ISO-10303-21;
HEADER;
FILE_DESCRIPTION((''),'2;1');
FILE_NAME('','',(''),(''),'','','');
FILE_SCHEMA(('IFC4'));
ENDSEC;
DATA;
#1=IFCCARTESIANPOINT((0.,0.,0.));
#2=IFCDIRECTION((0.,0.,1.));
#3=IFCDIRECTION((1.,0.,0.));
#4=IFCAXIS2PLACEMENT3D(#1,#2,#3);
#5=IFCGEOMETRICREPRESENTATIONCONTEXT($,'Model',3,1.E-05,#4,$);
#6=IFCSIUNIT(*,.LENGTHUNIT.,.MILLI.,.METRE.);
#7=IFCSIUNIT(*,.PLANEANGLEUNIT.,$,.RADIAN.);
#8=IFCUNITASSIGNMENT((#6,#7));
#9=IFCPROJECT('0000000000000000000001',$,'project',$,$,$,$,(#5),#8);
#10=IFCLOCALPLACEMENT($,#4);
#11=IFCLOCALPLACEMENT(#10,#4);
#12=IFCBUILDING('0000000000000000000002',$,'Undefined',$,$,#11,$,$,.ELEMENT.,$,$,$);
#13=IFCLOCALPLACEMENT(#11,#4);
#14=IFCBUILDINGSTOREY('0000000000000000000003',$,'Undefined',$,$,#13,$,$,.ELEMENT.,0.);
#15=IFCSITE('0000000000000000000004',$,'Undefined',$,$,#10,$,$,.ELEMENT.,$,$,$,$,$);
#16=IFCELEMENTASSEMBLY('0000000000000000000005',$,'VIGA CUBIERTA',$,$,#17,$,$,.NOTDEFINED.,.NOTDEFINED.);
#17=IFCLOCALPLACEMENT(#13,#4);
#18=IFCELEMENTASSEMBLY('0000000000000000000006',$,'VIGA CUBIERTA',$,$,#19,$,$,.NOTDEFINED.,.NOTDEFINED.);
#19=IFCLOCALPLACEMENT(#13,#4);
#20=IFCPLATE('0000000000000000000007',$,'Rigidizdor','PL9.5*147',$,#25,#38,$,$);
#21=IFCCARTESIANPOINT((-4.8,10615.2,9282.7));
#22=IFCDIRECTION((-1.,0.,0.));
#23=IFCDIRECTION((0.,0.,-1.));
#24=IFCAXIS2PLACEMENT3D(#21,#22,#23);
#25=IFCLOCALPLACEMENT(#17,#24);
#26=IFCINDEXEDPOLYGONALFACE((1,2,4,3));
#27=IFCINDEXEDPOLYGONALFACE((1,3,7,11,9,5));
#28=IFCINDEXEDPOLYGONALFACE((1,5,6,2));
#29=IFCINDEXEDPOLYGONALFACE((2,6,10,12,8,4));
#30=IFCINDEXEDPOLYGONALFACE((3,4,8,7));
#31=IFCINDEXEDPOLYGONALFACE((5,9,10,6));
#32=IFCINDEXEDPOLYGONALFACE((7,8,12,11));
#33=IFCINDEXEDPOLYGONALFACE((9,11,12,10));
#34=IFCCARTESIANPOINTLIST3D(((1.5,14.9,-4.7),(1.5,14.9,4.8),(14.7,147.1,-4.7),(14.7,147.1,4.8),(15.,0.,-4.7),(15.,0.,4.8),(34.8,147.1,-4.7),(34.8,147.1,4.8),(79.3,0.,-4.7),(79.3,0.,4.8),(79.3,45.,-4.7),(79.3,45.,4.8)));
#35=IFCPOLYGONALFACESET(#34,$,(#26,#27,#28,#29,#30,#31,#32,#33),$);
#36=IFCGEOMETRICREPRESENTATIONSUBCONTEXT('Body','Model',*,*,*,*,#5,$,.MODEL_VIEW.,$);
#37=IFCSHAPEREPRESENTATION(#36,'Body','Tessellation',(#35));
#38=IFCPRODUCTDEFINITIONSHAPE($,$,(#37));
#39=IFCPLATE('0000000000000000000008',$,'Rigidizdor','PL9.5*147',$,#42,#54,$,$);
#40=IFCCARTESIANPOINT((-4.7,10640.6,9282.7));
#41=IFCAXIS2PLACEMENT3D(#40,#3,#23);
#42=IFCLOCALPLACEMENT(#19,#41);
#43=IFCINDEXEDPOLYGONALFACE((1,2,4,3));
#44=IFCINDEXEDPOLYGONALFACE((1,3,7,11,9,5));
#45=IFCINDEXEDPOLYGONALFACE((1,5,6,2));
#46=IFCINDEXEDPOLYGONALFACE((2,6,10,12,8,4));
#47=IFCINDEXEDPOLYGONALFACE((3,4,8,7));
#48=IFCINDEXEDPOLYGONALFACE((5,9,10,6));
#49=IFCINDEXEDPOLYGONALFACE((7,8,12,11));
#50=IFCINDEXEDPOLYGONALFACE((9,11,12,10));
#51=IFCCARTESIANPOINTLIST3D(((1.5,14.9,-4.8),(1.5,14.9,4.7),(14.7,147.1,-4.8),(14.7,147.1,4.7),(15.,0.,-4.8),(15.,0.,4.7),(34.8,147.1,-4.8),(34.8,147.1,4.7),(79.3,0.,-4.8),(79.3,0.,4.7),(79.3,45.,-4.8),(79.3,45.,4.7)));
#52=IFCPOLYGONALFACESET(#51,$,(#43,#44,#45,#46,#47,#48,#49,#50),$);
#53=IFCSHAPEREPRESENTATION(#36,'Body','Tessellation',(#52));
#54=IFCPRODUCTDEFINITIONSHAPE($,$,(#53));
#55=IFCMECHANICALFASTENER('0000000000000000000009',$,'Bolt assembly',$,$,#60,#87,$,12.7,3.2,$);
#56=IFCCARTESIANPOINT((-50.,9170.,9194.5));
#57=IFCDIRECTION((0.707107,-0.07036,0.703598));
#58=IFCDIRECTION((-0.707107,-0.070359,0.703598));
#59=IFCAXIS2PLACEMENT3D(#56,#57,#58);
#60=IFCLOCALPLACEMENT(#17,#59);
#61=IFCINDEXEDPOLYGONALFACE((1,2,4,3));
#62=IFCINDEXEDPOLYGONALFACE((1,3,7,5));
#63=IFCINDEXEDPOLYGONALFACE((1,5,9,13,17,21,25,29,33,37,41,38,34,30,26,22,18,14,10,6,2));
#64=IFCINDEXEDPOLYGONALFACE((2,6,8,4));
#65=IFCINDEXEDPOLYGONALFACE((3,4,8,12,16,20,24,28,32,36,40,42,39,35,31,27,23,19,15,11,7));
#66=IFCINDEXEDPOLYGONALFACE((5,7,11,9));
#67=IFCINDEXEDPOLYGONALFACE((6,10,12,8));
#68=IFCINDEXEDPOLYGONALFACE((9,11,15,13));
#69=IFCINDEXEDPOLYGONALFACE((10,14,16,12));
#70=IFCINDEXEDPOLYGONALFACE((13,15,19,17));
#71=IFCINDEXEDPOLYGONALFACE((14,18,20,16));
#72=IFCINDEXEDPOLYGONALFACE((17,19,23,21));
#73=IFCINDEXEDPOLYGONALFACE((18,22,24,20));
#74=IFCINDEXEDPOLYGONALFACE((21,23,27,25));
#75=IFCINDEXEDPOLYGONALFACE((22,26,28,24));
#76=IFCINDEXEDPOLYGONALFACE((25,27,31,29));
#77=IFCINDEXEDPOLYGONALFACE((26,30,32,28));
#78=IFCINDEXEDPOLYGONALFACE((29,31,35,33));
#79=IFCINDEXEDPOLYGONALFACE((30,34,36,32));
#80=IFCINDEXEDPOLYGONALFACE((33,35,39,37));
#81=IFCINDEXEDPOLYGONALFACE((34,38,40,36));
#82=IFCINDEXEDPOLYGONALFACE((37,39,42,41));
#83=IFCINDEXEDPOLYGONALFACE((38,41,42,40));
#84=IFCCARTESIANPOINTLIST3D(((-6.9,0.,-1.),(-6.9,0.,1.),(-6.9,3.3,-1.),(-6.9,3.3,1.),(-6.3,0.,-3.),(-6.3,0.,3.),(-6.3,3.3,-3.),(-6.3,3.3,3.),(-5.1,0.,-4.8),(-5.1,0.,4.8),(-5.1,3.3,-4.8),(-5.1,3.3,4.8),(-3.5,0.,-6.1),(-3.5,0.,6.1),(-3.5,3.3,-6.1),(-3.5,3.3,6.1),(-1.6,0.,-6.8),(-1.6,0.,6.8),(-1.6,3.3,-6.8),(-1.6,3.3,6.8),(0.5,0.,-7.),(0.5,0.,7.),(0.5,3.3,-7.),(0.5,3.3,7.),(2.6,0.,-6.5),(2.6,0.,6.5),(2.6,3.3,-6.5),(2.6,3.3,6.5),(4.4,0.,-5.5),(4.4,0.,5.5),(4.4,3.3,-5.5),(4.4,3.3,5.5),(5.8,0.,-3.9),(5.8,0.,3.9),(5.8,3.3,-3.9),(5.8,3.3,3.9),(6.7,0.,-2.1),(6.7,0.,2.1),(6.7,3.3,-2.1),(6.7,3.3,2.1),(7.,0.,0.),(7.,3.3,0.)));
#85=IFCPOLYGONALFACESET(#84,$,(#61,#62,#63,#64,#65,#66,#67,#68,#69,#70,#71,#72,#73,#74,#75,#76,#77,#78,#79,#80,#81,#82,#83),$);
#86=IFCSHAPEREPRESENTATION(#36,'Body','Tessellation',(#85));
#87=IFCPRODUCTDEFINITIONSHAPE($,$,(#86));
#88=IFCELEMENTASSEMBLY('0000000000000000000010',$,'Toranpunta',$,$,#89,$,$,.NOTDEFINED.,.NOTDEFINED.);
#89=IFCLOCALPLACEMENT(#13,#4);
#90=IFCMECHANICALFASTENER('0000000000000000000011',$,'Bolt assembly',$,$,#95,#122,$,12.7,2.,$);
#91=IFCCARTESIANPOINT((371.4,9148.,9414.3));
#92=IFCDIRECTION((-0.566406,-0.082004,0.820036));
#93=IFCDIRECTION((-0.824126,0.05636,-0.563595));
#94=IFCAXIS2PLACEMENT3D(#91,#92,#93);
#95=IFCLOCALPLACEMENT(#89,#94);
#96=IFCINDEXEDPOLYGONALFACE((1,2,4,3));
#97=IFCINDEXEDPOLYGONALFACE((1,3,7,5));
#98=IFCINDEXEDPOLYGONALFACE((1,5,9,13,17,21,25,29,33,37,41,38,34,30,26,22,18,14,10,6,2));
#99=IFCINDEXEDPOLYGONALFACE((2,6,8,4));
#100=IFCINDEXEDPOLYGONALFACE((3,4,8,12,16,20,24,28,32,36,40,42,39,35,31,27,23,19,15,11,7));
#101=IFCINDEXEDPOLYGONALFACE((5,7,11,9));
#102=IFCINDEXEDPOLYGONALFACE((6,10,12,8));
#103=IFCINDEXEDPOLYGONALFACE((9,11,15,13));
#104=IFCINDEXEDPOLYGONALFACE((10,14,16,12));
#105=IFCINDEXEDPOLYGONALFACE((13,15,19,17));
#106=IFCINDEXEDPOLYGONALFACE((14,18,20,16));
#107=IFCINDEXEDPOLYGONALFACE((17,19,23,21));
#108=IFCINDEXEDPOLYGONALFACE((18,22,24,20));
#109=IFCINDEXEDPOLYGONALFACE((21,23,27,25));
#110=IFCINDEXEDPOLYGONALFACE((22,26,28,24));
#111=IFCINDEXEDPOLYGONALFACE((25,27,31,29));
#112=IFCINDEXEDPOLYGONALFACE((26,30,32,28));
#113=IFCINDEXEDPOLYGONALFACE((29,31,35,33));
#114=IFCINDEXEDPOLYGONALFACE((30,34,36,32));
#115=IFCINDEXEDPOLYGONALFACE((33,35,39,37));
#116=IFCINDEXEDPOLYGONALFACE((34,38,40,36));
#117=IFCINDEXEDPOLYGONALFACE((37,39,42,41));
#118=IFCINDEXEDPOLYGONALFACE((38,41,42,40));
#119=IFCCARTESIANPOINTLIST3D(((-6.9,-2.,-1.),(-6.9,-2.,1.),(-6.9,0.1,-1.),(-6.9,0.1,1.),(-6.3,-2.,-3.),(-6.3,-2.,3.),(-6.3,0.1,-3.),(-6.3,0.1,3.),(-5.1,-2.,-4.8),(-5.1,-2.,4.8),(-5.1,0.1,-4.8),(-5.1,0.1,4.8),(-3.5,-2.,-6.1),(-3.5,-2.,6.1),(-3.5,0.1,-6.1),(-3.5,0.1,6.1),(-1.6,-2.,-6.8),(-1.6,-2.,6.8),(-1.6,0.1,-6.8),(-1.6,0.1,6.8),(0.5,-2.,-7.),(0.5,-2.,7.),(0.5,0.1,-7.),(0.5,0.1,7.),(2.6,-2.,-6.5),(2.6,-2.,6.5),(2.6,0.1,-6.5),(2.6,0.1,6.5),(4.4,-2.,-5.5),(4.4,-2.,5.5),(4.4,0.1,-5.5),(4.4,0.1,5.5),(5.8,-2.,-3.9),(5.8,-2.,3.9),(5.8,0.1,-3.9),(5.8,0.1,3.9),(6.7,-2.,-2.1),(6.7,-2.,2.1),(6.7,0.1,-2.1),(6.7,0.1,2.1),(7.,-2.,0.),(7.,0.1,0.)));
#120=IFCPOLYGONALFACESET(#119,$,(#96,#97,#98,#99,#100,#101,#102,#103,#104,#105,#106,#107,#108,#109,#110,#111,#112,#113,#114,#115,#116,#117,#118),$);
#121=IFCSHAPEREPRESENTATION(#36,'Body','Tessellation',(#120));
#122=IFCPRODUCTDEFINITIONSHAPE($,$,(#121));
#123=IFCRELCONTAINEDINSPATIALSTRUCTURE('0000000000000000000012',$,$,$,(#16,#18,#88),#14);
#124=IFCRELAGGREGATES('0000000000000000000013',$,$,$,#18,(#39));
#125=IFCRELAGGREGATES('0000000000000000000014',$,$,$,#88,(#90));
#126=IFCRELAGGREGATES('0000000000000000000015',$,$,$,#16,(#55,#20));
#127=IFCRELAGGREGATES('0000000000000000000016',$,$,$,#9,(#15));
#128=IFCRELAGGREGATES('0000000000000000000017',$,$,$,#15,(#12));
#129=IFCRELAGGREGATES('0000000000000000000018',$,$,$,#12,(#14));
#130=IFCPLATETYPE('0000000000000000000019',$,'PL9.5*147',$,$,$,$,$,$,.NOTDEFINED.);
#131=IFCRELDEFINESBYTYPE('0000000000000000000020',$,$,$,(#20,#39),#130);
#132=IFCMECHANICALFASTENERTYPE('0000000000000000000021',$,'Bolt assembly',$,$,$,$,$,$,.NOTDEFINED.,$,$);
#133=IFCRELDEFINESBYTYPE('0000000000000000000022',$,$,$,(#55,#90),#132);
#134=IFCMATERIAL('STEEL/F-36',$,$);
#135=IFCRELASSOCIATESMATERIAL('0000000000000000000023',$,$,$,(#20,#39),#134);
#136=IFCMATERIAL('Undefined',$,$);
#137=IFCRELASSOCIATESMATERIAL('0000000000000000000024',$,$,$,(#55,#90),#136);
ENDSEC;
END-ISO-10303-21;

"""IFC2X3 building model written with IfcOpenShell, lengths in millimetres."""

from ifc_helpers import new_model, si_unit, frame, origin_with_axes, origin_2d_with_axis, place, context, subcontext, project, spatial, polyline, circle, outline, extrude, source, transform, mapped, material, type_object, element, aggregate, save


model = new_model("IFC2X3")

# Units and contexts
model_context = context("Model", 3, precision=1e-05, world=origin_with_axes())
body_context = subcontext(model_context, "Body", "Model", "MODEL_VIEW")
ifc_project = project(units=[si_unit("LENGTHUNIT", "METRE", prefix="MILLI"), si_unit("PLANEANGLEUNIT", "RADIAN")], contexts=[model_context])

# Site, building, storey
site_placement = place(None, origin_with_axes())
site = spatial("IfcSite", under=ifc_project, at=site_placement, Name="Undefined", CompositionType="ELEMENT")
building_placement = place(site_placement, origin_with_axes())
building = spatial("IfcBuilding", under=site, at=building_placement, Name="Undefined", CompositionType="ELEMENT")
storey_placement = place(building_placement, origin_with_axes())
storey = spatial("IfcBuildingStorey", under=building, at=storey_placement, Name="Undefined", CompositionType="ELEMENT", Elevation=0.0)

# Element assemblies
assembly_1_placement = place(storey_placement, origin_with_axes())
assembly_1 = element("IfcElementAssembly", 1, at=assembly_1_placement, inside=storey, Name="VIGA CUBIERTA", AssemblyPlace="NOTDEFINED", PredefinedType="NOTDEFINED")
ifc_material_1 = material(Name="STEEL/F-36")
assembly_2_placement = place(storey_placement, origin_with_axes())
assembly_2 = element("IfcElementAssembly", 2, at=assembly_2_placement, inside=storey, Name="VIGA CUBIERTA", AssemblyPlace="NOTDEFINED", PredefinedType="NOTDEFINED")

# Plates
plate_type_1 = type_object("IfcPlateType", Name="PL9.5*147", PredefinedType="NOTDEFINED")
plate_1_placement = place(assembly_1_placement, frame((-4.8, 10615.2, 9282.7), z_axis=(-1.0, 0.0, 0.0), x_axis=(0.0, 0.0, -1.0)))
plate_1 = element("IfcPlate", 3, at=plate_1_placement, type_object=plate_type_1, material=ifc_material_1, Name="Rigidizdor", Description="PL9.5*147", context=body_context, shape_type="SweptSolid", body=[
    extrude(outline(polyline([(1.5, 14.9), (15.0, 0.0), (79.3, 0.0), (79.3, 45.0), (34.8, 147.1), (14.7, 147.1), (1.5, 14.9)])), frame((0.0, 0.0, -4.7), z_axis=(0.0, 0.0, 1.0), x_axis=(1.0, 0.0, 0.0)), (0.0, 0.0, 1.0), 9.5),
])
plate_2_placement = place(assembly_2_placement, frame((-4.7, 10640.6, 9282.7), z_axis=(1.0, 0.0, 0.0), x_axis=(0.0, 0.0, -1.0)))
plate_2 = element("IfcPlate", 4, at=plate_2_placement, type_object=plate_type_1, material=ifc_material_1, Name="Rigidizdor", Description="PL9.5*147", context=body_context, shape_type="SweptSolid", body=[
    extrude(outline(polyline([(1.5, 14.9), (15.0, 0.0), (79.3, 0.0), (79.3, 45.0), (34.8, 147.1), (14.7, 147.1), (1.5, 14.9)])), frame((0.0, 0.0, -4.7), z_axis=(0.0, 0.0, 1.0), x_axis=(1.0, 0.0, 0.0)), (0.0, 0.0, 1.0), 9.5),
])
aggregate(assembly_2, [plate_2])

# Mechanical fastener
ifc_material_2 = material(Name="Undefined")
mechanical_fastener_type = type_object("IfcMechanicalFastenerType", Name="Bolt assembly")
shared_shape_1 = source(origin_with_axes(), body_context, "Body", "SweptSolid", [
    extrude(circle(Radius=7.0, at=origin_2d_with_axis()), frame((0.0, 0.0, 0.0), z_axis=(0.0, 1.0, 0.0), x_axis=(1.0, 0.0, 0.0)), (0.0, 0.0, 1.0), 3.3),
])
mechanical_fastener_1_placement = place(assembly_1_placement, frame((-50.0, 9170.0, 9194.5), z_axis=(0.707107, -0.07036, 0.703598), x_axis=(-0.707107, -0.070359, 0.703598)))
mechanical_fastener_1 = element("IfcMechanicalFastener", 5, at=mechanical_fastener_1_placement, type_object=mechanical_fastener_type, material=ifc_material_2, Name="Bolt assembly", NominalDiameter=12.7, NominalLength=3.2, context=body_context, shape_type="MappedRepresentation", body=[
    mapped(shared_shape_1, transform((0.0, 0.0, 0.0))),
])

# Element assembly, mechanical fastener
assembly_3_placement = place(storey_placement, origin_with_axes())
assembly_3 = element("IfcElementAssembly", 6, at=assembly_3_placement, inside=storey, Name="Toranpunta", AssemblyPlace="NOTDEFINED", PredefinedType="NOTDEFINED")
shared_shape_2 = source(origin_with_axes(), body_context, "Body", "SweptSolid", [
    extrude(circle(Radius=7.0, at=origin_2d_with_axis()), frame((0.0, -2.0, 0.0), z_axis=(0.0, 1.0, 0.0), x_axis=(1.0, 0.0, 0.0)), (0.0, 0.0, 1.0), 2.1),
])
mechanical_fastener_2_placement = place(assembly_3_placement, frame((371.4, 9148.0, 9414.3), z_axis=(-0.566406, -0.082004, 0.820036), x_axis=(-0.824126, 0.05636, -0.563595)))
mechanical_fastener_2 = element("IfcMechanicalFastener", 7, at=mechanical_fastener_2_placement, type_object=mechanical_fastener_type, material=ifc_material_2, Name="Bolt assembly", NominalDiameter=12.7, NominalLength=2.0, context=body_context, shape_type="MappedRepresentation", body=[
    mapped(shared_shape_2, transform((0.0, 0.0, 0.0))),
])
aggregate(assembly_3, [mechanical_fastener_2])

aggregate(assembly_1, [mechanical_fastener_1, plate_1])

save(model, "model.ifc")
